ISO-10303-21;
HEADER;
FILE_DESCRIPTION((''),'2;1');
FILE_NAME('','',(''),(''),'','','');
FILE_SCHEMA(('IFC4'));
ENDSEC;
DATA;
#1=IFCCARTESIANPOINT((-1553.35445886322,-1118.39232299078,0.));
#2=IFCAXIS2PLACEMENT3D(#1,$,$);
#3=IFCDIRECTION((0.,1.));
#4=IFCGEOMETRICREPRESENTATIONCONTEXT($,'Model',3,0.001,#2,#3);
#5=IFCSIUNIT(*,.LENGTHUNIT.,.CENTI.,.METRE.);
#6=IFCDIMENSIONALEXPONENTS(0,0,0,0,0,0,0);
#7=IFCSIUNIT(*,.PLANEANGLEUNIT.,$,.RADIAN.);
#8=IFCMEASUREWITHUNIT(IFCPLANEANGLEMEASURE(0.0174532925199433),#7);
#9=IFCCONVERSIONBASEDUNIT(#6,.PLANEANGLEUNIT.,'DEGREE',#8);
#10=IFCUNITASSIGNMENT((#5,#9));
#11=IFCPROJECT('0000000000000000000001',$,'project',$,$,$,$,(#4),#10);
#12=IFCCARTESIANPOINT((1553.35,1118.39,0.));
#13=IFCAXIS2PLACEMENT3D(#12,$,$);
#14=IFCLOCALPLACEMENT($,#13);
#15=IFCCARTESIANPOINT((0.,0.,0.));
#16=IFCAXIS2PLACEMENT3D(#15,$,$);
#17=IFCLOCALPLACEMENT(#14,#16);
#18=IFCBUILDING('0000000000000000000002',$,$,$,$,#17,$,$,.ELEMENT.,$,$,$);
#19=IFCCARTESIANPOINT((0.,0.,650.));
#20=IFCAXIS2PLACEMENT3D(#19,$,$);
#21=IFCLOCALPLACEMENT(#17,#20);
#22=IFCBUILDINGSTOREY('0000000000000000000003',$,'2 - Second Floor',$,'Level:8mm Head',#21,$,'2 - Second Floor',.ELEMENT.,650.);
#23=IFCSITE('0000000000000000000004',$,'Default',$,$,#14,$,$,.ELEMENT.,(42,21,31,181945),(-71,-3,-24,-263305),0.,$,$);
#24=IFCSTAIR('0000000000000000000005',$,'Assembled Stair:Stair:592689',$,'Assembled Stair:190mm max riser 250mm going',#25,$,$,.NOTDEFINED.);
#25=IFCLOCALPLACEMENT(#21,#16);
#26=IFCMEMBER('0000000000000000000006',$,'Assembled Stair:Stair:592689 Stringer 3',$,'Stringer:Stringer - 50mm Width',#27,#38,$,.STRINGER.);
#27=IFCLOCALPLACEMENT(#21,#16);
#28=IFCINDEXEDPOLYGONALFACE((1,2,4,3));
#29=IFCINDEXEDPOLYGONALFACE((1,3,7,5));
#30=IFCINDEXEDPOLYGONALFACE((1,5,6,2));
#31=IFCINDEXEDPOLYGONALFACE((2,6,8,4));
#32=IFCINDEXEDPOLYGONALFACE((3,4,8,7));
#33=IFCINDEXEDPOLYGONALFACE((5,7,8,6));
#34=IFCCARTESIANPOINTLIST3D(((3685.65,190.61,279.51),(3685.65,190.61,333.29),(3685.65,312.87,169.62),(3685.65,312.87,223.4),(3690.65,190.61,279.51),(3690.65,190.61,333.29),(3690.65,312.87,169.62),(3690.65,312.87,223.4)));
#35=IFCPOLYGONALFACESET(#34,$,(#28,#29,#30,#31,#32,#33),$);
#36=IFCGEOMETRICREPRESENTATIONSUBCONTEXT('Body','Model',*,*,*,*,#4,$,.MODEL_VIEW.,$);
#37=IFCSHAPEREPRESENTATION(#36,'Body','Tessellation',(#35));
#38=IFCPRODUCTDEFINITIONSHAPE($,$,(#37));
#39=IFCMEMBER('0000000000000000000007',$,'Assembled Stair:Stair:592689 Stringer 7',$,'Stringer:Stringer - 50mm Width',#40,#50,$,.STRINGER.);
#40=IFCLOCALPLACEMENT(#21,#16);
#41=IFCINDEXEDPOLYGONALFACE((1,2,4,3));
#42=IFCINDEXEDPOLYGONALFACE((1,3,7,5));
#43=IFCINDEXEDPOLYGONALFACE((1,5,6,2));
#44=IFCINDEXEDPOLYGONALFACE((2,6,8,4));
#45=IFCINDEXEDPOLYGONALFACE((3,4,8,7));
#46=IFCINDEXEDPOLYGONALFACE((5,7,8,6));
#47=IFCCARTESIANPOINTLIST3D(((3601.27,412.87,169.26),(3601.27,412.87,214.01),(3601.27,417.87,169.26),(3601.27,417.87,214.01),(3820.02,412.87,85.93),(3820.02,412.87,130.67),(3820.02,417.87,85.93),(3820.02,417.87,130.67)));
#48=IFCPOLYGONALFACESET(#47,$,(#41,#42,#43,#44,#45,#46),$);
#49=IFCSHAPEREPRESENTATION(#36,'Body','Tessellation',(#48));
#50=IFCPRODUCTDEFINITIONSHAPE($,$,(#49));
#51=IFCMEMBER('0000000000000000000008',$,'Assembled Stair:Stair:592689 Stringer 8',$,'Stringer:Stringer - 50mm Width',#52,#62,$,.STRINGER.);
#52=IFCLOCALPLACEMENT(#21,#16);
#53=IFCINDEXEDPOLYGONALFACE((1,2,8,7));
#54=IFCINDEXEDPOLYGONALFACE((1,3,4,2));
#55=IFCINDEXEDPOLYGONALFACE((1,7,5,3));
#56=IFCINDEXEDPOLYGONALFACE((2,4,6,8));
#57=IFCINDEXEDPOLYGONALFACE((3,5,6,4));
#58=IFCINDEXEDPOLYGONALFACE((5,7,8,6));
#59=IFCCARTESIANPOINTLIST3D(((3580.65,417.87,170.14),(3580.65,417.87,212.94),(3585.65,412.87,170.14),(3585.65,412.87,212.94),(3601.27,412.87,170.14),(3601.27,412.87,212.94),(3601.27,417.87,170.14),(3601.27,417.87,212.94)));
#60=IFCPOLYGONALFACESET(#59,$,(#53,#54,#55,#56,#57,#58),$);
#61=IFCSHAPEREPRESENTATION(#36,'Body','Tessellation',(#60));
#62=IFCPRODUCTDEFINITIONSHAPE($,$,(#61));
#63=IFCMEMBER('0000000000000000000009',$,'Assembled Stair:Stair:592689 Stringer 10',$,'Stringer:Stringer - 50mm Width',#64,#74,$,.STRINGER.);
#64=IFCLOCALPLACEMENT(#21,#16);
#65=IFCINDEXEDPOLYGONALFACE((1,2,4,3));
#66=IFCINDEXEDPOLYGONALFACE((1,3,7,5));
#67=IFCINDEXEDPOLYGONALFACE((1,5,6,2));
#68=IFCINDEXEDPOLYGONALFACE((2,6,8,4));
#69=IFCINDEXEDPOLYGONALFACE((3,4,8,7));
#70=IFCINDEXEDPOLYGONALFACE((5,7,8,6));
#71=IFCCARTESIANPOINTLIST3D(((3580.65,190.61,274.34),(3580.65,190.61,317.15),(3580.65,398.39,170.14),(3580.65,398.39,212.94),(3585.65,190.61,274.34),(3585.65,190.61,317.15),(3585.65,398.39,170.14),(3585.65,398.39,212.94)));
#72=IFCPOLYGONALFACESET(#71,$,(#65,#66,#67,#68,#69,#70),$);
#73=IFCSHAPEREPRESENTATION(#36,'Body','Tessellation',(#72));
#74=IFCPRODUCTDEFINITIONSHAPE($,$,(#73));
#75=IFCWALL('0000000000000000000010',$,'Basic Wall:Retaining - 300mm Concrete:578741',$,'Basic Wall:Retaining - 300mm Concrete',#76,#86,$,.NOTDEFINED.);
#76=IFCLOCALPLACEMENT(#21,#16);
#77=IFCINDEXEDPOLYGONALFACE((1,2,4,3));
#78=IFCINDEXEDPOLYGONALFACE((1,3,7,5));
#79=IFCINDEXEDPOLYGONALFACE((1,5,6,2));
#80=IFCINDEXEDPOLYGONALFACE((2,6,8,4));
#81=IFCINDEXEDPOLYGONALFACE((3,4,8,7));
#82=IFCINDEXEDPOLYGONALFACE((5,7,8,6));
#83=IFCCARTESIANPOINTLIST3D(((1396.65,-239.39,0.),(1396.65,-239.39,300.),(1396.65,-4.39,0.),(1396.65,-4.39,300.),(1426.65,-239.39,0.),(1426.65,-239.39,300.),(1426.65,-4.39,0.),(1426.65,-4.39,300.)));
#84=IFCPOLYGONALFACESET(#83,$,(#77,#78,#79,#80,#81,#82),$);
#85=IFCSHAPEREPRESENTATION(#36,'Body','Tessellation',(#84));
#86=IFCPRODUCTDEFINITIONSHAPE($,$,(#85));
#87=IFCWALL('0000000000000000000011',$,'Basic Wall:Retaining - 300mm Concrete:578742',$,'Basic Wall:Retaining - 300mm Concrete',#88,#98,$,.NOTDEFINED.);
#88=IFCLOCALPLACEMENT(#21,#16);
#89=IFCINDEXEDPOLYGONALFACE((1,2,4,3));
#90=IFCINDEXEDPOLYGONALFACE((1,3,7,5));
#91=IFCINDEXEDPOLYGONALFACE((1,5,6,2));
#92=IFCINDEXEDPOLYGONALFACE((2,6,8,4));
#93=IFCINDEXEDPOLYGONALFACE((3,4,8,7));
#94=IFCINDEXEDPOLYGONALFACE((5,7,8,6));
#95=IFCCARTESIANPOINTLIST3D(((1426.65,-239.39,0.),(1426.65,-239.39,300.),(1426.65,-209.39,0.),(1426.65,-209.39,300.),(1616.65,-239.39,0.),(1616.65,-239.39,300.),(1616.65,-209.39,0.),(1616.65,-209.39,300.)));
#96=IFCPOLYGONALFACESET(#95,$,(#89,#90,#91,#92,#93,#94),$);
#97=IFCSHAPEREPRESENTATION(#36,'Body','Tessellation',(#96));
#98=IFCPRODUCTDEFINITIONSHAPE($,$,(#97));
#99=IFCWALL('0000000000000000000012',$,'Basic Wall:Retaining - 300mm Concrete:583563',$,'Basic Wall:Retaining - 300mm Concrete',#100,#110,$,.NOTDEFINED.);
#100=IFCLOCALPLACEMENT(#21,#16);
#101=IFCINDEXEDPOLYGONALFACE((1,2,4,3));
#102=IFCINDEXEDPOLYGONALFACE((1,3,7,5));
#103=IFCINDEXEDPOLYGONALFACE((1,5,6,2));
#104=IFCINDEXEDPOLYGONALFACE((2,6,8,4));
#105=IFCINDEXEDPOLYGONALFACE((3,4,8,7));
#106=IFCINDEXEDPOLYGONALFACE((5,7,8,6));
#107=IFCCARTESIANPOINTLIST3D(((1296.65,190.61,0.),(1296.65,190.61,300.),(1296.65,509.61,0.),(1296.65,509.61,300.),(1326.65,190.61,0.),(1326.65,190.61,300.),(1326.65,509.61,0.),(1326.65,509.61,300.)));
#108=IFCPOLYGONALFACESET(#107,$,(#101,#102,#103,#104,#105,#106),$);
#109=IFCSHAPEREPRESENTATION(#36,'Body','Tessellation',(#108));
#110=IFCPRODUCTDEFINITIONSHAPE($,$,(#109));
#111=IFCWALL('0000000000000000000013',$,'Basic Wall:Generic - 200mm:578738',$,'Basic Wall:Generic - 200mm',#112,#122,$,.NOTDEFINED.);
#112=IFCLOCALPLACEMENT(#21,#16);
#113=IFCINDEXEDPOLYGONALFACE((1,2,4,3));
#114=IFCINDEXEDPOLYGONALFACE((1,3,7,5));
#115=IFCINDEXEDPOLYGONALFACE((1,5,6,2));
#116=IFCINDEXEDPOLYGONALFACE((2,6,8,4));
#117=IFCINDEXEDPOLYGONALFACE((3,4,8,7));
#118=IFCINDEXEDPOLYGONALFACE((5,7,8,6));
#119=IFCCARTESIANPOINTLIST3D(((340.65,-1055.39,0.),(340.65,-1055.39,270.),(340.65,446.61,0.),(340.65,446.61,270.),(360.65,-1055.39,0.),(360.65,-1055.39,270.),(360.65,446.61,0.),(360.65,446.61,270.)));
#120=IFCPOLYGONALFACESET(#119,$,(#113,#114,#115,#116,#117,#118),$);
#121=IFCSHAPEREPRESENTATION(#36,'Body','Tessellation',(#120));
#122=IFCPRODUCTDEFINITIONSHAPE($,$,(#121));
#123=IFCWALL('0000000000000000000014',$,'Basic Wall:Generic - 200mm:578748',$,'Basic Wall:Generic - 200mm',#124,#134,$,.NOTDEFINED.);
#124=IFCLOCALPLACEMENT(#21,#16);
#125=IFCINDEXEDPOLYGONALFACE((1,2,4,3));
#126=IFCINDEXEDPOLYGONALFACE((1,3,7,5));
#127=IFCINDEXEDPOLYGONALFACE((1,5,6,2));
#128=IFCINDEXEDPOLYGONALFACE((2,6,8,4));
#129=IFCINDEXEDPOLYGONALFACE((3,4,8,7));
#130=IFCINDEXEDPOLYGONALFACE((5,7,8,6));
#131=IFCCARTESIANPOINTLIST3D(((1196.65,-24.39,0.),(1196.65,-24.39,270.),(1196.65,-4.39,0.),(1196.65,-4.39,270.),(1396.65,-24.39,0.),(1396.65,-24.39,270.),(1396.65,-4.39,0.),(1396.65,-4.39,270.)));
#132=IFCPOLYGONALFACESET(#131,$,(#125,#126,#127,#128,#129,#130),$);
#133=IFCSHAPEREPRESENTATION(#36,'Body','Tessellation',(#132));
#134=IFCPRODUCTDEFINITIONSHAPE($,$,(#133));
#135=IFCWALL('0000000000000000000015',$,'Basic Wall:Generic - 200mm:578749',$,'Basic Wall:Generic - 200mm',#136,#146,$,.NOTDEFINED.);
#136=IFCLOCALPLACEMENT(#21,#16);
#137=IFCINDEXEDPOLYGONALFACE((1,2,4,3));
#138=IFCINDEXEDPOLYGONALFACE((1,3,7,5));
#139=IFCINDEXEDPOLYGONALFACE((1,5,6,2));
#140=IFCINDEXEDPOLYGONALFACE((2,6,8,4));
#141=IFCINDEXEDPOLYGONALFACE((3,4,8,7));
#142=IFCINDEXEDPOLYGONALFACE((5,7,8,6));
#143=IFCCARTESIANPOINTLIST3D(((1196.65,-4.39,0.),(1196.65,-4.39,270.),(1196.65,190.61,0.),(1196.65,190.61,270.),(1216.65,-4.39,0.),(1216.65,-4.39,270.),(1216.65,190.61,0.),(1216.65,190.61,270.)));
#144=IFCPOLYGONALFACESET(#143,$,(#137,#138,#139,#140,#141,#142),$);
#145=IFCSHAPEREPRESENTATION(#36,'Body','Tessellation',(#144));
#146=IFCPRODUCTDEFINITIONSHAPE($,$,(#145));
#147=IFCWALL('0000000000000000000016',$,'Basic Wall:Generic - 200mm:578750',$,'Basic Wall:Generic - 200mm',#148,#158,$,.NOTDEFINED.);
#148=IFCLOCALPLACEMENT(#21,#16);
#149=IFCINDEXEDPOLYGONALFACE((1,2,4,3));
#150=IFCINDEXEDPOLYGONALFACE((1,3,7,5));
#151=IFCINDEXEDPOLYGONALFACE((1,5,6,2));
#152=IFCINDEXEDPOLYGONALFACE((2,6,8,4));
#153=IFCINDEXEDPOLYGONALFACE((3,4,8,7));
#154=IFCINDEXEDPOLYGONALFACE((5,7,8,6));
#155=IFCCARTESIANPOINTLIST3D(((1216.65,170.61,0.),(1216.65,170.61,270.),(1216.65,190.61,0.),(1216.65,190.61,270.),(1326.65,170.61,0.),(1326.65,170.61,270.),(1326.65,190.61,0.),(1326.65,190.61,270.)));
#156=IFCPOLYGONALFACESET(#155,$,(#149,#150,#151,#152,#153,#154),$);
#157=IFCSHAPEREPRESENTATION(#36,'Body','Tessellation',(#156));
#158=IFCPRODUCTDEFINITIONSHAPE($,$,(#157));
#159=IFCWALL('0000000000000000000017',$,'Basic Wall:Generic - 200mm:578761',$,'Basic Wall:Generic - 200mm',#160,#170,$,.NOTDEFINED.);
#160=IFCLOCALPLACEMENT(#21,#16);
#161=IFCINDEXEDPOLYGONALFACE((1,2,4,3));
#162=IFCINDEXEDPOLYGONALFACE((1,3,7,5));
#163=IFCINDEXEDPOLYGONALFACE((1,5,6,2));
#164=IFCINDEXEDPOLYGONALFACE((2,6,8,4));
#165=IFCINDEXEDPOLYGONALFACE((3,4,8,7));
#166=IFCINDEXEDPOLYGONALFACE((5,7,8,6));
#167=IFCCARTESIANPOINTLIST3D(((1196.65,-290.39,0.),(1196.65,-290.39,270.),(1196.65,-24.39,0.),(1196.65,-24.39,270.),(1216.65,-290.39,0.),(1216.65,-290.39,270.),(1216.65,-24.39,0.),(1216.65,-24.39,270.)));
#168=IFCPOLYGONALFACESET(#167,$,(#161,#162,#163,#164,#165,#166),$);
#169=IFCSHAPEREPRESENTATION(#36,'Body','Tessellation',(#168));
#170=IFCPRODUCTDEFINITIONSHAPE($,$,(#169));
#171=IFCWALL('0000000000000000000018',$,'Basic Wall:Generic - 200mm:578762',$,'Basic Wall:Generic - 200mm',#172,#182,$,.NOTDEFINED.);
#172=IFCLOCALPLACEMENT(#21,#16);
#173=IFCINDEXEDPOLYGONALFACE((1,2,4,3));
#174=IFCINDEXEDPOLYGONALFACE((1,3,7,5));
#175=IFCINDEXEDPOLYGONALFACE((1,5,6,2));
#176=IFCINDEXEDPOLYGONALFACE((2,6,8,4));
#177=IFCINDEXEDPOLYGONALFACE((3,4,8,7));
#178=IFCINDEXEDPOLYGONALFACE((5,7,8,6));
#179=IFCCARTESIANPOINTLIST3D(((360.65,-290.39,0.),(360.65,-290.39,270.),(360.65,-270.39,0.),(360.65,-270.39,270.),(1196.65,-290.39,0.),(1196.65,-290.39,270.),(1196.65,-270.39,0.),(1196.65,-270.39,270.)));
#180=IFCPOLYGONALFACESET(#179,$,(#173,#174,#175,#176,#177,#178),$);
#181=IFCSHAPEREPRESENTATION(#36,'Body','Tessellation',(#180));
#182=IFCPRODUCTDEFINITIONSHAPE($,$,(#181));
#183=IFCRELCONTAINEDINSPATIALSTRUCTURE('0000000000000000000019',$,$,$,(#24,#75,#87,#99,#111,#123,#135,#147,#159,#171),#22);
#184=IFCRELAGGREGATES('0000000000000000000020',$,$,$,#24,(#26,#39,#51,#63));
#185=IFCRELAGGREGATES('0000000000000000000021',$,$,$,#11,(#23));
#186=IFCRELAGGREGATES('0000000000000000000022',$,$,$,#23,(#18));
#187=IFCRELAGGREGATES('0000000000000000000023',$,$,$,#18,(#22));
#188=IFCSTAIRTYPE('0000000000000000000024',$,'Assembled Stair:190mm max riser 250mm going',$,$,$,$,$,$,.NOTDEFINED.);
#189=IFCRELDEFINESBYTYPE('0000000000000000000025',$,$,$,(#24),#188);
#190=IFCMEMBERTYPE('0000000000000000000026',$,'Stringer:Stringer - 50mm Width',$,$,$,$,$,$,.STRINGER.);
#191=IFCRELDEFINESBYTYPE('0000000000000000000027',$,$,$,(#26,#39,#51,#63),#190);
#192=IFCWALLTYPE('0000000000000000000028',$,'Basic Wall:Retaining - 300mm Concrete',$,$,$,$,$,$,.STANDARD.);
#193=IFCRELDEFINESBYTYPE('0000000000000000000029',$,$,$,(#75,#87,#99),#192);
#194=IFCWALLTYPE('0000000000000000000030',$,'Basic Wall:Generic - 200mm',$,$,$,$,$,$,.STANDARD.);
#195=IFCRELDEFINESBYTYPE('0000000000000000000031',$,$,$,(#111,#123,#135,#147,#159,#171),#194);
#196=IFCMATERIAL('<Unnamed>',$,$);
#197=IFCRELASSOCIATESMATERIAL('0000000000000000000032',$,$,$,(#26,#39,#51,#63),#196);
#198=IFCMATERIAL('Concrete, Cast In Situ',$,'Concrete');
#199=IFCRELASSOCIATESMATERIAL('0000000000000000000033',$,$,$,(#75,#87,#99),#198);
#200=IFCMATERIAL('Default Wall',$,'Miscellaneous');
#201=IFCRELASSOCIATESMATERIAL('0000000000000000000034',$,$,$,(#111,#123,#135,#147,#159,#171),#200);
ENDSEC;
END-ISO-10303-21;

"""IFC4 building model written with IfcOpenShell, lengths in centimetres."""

from ifc_helpers import new_model, entity, si_unit, converted_unit, direction, frame, origin, place, context, subcontext, project, spatial, indexed_curve, outline, extrude, material, type_object, element, aggregate, save


model = new_model("IFC4")

# Units and contexts
model_context = context("Model", 3, precision=0.001, world=frame((-1553.35445886322, -1118.39232299078, 0.0)), true_north=direction((0.0, 1.0)))
body_context = subcontext(model_context, "Body", "Model", "MODEL_VIEW")
ifc_project = project(units=[si_unit("LENGTHUNIT", "METRE", prefix="CENTI"), converted_unit("PLANEANGLEUNIT", "DEGREE", entity("IfcPlaneAngleMeasure", 0.0174532925199433), si_unit("PLANEANGLEUNIT", "RADIAN"), dimensions=[0, 0, 0, 0, 0, 0, 0])], contexts=[model_context])

# Site, building, storey
site_placement = place(None, frame((1553.35, 1118.39, 0.0)))
site = spatial("IfcSite", under=ifc_project, at=site_placement, Name="Default", CompositionType="ELEMENT", RefLatitude=(42, 21, 31, 181945), RefLongitude=(-71, -3, -24, -263305), RefElevation=0.0)
building_placement = place(site_placement, origin())
building = spatial("IfcBuilding", under=site, at=building_placement, CompositionType="ELEMENT")
storey_placement = place(building_placement, frame((0.0, 0.0, 650.0)))
storey = spatial("IfcBuildingStorey", under=building, at=storey_placement, Name="2 - Second Floor", ObjectType="Level:8mm Head", LongName="2 - Second Floor", CompositionType="ELEMENT", Elevation=650.0)

# Stair, members
stair_type = type_object("IfcStairType", Name="Assembled Stair:190mm max riser 250mm going", PredefinedType="NOTDEFINED")
stair_placement = place(storey_placement, origin())
stair = element("IfcStair", 1, at=stair_placement, inside=storey, type_object=stair_type, Name="Assembled Stair:Stair:592689", ObjectType="Assembled Stair:190mm max riser 250mm going", PredefinedType="NOTDEFINED")
ifc_material_1 = material(Name="<Unnamed>")
member_type = type_object("IfcMemberType", Name="Stringer:Stringer - 50mm Width", PredefinedType="STRINGER")
member_1_placement = place(stair_placement, origin())
member_1 = element("IfcMember", 2, at=member_1_placement, type_object=member_type, material=ifc_material_1, Name="Assembled Stair:Stair:592689 Stringer 3", ObjectType="Stringer:Stringer - 50mm Width", PredefinedType="STRINGER", context=body_context, shape_type="SweptSolid", body=[
    extrude(outline(indexed_curve([(-64.22, -20.0), (100.17, -20.0), (64.22, 20.0), (-100.17, 20.0), (-64.22, -20.0)], self_intersect=False)), frame((3685.65, 251.74, 251.46), z_axis=(1.0, 0.0, 0.0), x_axis=(0.0, -0.74373, 0.668481)), (0.0, 0.0, 1.0), 5.0),
])
member_2_placement = place(stair_placement, origin())
member_2 = element("IfcMember", 3, at=member_2_placement, type_object=member_type, material=ifc_material_1, Name="Assembled Stair:Stair:592689 Stringer 7", ObjectType="Stringer:Stringer - 50mm Width", PredefinedType="STRINGER", context=body_context, shape_type="SweptSolid", body=[
    extrude(outline(indexed_curve([(-125.01, -20.91), (109.08, -20.91), (125.01, 20.91), (-109.08, 20.91), (-125.01, -20.91)], self_intersect=False)), frame((3710.65, 412.87, 149.97), z_axis=(0.0, 1.0, 0.0), x_axis=(-0.934489, 0.0, 0.355992)), (0.0, 0.0, 1.0), 5.0),
])
member_3_placement = place(stair_placement, origin())
member_3 = element("IfcMember", 4, at=member_3_placement, type_object=member_type, material=ifc_material_1, Name="Assembled Stair:Stair:592689 Stringer 8", ObjectType="Stringer:Stringer - 50mm Width", PredefinedType="STRINGER", context=body_context, shape_type="SweptSolid", body=[
    extrude(outline(indexed_curve([(-9.06, -2.5), (11.56, -2.5), (6.56, 2.5), (-9.06, 2.5), (-9.06, -2.5)], self_intersect=False)), frame((3592.21, 415.37, 170.14), z_axis=(0.0, 0.0, 1.0), x_axis=(-1.0, 0.0, 0.0)), (0.0, 0.0, 1.0), 42.8),
])
member_4_placement = place(stair_placement, origin())
member_4 = element("IfcMember", 5, at=member_4_placement, type_object=member_type, material=ifc_material_1, Name="Assembled Stair:Stair:592689 Stringer 10", ObjectType="Stringer:Stringer - 50mm Width", PredefinedType="STRINGER", context=body_context, shape_type="SweptSolid", body=[
    extrude(outline(indexed_curve([(-106.63, -19.13), (125.82, -19.13), (106.63, 19.13), (-125.82, 19.13), (-106.63, -19.13)], self_intersect=False)), frame((3580.65, 294.5, 243.64), z_axis=(1.0, 0.0, 0.0), x_axis=(0.0, -0.893886, 0.448294)), (0.0, 0.0, 1.0), 5.0),
])
aggregate(stair, [member_1, member_2, member_3, member_4])

# Walls
ifc_material_2 = material(Name="Concrete, Cast In Situ", Category="Concrete")
wall_type_1 = type_object("IfcWallType", Name="Basic Wall:Retaining - 300mm Concrete", PredefinedType="STANDARD")
wall_1_placement = place(storey_placement, frame((1411.65, -4.39, 0.0), z_axis=(0.0, 0.0, 1.0), x_axis=(0.0, -1.0, 0.0)))
element("IfcWall", 6, at=wall_1_placement, inside=storey, type_object=wall_type_1, material=ifc_material_2, Name="Basic Wall:Retaining - 300mm Concrete:578741", ObjectType="Basic Wall:Retaining - 300mm Concrete", PredefinedType="NOTDEFINED", context=body_context, shape_type="SweptSolid", body=[
    extrude(outline(indexed_curve([(235.0, 15.0), (0.0, 15.0), (0.0, -15.0), (235.0, -15.0), (235.0, 15.0)], self_intersect=False)), origin(), (0.0, 0.0, 1.0), 300.0),
])
wall_2_placement = place(storey_placement, frame((1426.65, -224.39, 0.0)))
element("IfcWall", 7, at=wall_2_placement, inside=storey, type_object=wall_type_1, material=ifc_material_2, Name="Basic Wall:Retaining - 300mm Concrete:578742", ObjectType="Basic Wall:Retaining - 300mm Concrete", PredefinedType="NOTDEFINED", context=body_context, shape_type="SweptSolid", body=[
    extrude(outline(indexed_curve([(190.0, 15.0), (0.0, 15.0), (0.0, -15.0), (190.0, -15.0), (190.0, 15.0)], self_intersect=False)), origin(), (0.0, 0.0, 1.0), 300.0),
])
wall_3_placement = place(storey_placement, frame((1311.65, 509.61, 0.0), z_axis=(0.0, 0.0, 1.0), x_axis=(0.0, -1.0, 0.0)))
element("IfcWall", 8, at=wall_3_placement, inside=storey, type_object=wall_type_1, material=ifc_material_2, Name="Basic Wall:Retaining - 300mm Concrete:583563", ObjectType="Basic Wall:Retaining - 300mm Concrete", PredefinedType="NOTDEFINED", context=body_context, shape_type="SweptSolid", body=[
    extrude(outline(indexed_curve([(319.0, 15.0), (0.0, 15.0), (0.0, -15.0), (319.0, -15.0), (319.0, 15.0)], self_intersect=False)), origin(), (0.0, 0.0, 1.0), 300.0),
])
ifc_material_3 = material(Name="Default Wall", Category="Miscellaneous")
wall_type_2 = type_object("IfcWallType", Name="Basic Wall:Generic - 200mm", PredefinedType="STANDARD")
wall_4_placement = place(storey_placement, frame((350.65, 446.61, 0.0), z_axis=(0.0, 0.0, 1.0), x_axis=(0.0, -1.0, 0.0)))
element("IfcWall", 9, at=wall_4_placement, inside=storey, type_object=wall_type_2, material=ifc_material_3, Name="Basic Wall:Generic - 200mm:578738", ObjectType="Basic Wall:Generic - 200mm", PredefinedType="NOTDEFINED", context=body_context, shape_type="SweptSolid", body=[
    extrude(outline(indexed_curve([(1502.0, 10.0), (0.0, 10.0), (0.0, -10.0), (1502.0, -10.0), (1502.0, 10.0)], self_intersect=False)), origin(), (0.0, 0.0, 1.0), 270.0),
])
wall_5_placement = place(storey_placement, frame((1396.65, -14.39, 0.0), z_axis=(0.0, 0.0, 1.0), x_axis=(-1.0, 0.0, 0.0)))
element("IfcWall", 10, at=wall_5_placement, inside=storey, type_object=wall_type_2, material=ifc_material_3, Name="Basic Wall:Generic - 200mm:578748", ObjectType="Basic Wall:Generic - 200mm", PredefinedType="NOTDEFINED", context=body_context, shape_type="SweptSolid", body=[
    extrude(outline(indexed_curve([(200.0, 10.0), (0.0, 10.0), (0.0, -10.0), (200.0, -10.0), (200.0, 10.0)], self_intersect=False)), origin(), (0.0, 0.0, 1.0), 270.0),
])
wall_6_placement = place(storey_placement, frame((1206.65, -4.39, 0.0), z_axis=(0.0, 0.0, 1.0), x_axis=(0.0, 1.0, 0.0)))
element("IfcWall", 11, at=wall_6_placement, inside=storey, type_object=wall_type_2, material=ifc_material_3, Name="Basic Wall:Generic - 200mm:578749", ObjectType="Basic Wall:Generic - 200mm", PredefinedType="NOTDEFINED", context=body_context, shape_type="SweptSolid", body=[
    extrude(outline(indexed_curve([(195.0, 10.0), (0.0, 10.0), (0.0, -10.0), (195.0, -10.0), (195.0, 10.0)], self_intersect=False)), origin(), (0.0, 0.0, 1.0), 270.0),
])
wall_7_placement = place(storey_placement, frame((1216.65, 180.61, 0.0)))
element("IfcWall", 12, at=wall_7_placement, inside=storey, type_object=wall_type_2, material=ifc_material_3, Name="Basic Wall:Generic - 200mm:578750", ObjectType="Basic Wall:Generic - 200mm", PredefinedType="NOTDEFINED", context=body_context, shape_type="SweptSolid", body=[
    extrude(outline(indexed_curve([(110.0, 10.0), (0.0, 10.0), (0.0, -10.0), (110.0, -10.0), (110.0, 10.0)], self_intersect=False)), origin(), (0.0, 0.0, 1.0), 270.0),
])
wall_8_placement = place(storey_placement, frame((1206.65, -24.39, 0.0), z_axis=(0.0, 0.0, 1.0), x_axis=(0.0, -1.0, 0.0)))
element("IfcWall", 13, at=wall_8_placement, inside=storey, type_object=wall_type_2, material=ifc_material_3, Name="Basic Wall:Generic - 200mm:578761", ObjectType="Basic Wall:Generic - 200mm", PredefinedType="NOTDEFINED", context=body_context, shape_type="SweptSolid", body=[
    extrude(outline(indexed_curve([(266.0, 10.0), (0.0, 10.0), (0.0, -10.0), (266.0, -10.0), (266.0, 10.0)], self_intersect=False)), origin(), (0.0, 0.0, 1.0), 270.0),
])
wall_9_placement = place(storey_placement, frame((1196.65, -280.39, 0.0), z_axis=(0.0, 0.0, 1.0), x_axis=(-1.0, 0.0, 0.0)))
element("IfcWall", 14, at=wall_9_placement, inside=storey, type_object=wall_type_2, material=ifc_material_3, Name="Basic Wall:Generic - 200mm:578762", ObjectType="Basic Wall:Generic - 200mm", PredefinedType="NOTDEFINED", context=body_context, shape_type="SweptSolid", body=[
    extrude(outline(indexed_curve([(836.0, 10.0), (0.0, 10.0), (0.0, -10.0), (836.0, -10.0), (836.0, 10.0)], self_intersect=False)), origin(), (0.0, 0.0, 1.0), 270.0),
])

save(model, "model.ifc")
